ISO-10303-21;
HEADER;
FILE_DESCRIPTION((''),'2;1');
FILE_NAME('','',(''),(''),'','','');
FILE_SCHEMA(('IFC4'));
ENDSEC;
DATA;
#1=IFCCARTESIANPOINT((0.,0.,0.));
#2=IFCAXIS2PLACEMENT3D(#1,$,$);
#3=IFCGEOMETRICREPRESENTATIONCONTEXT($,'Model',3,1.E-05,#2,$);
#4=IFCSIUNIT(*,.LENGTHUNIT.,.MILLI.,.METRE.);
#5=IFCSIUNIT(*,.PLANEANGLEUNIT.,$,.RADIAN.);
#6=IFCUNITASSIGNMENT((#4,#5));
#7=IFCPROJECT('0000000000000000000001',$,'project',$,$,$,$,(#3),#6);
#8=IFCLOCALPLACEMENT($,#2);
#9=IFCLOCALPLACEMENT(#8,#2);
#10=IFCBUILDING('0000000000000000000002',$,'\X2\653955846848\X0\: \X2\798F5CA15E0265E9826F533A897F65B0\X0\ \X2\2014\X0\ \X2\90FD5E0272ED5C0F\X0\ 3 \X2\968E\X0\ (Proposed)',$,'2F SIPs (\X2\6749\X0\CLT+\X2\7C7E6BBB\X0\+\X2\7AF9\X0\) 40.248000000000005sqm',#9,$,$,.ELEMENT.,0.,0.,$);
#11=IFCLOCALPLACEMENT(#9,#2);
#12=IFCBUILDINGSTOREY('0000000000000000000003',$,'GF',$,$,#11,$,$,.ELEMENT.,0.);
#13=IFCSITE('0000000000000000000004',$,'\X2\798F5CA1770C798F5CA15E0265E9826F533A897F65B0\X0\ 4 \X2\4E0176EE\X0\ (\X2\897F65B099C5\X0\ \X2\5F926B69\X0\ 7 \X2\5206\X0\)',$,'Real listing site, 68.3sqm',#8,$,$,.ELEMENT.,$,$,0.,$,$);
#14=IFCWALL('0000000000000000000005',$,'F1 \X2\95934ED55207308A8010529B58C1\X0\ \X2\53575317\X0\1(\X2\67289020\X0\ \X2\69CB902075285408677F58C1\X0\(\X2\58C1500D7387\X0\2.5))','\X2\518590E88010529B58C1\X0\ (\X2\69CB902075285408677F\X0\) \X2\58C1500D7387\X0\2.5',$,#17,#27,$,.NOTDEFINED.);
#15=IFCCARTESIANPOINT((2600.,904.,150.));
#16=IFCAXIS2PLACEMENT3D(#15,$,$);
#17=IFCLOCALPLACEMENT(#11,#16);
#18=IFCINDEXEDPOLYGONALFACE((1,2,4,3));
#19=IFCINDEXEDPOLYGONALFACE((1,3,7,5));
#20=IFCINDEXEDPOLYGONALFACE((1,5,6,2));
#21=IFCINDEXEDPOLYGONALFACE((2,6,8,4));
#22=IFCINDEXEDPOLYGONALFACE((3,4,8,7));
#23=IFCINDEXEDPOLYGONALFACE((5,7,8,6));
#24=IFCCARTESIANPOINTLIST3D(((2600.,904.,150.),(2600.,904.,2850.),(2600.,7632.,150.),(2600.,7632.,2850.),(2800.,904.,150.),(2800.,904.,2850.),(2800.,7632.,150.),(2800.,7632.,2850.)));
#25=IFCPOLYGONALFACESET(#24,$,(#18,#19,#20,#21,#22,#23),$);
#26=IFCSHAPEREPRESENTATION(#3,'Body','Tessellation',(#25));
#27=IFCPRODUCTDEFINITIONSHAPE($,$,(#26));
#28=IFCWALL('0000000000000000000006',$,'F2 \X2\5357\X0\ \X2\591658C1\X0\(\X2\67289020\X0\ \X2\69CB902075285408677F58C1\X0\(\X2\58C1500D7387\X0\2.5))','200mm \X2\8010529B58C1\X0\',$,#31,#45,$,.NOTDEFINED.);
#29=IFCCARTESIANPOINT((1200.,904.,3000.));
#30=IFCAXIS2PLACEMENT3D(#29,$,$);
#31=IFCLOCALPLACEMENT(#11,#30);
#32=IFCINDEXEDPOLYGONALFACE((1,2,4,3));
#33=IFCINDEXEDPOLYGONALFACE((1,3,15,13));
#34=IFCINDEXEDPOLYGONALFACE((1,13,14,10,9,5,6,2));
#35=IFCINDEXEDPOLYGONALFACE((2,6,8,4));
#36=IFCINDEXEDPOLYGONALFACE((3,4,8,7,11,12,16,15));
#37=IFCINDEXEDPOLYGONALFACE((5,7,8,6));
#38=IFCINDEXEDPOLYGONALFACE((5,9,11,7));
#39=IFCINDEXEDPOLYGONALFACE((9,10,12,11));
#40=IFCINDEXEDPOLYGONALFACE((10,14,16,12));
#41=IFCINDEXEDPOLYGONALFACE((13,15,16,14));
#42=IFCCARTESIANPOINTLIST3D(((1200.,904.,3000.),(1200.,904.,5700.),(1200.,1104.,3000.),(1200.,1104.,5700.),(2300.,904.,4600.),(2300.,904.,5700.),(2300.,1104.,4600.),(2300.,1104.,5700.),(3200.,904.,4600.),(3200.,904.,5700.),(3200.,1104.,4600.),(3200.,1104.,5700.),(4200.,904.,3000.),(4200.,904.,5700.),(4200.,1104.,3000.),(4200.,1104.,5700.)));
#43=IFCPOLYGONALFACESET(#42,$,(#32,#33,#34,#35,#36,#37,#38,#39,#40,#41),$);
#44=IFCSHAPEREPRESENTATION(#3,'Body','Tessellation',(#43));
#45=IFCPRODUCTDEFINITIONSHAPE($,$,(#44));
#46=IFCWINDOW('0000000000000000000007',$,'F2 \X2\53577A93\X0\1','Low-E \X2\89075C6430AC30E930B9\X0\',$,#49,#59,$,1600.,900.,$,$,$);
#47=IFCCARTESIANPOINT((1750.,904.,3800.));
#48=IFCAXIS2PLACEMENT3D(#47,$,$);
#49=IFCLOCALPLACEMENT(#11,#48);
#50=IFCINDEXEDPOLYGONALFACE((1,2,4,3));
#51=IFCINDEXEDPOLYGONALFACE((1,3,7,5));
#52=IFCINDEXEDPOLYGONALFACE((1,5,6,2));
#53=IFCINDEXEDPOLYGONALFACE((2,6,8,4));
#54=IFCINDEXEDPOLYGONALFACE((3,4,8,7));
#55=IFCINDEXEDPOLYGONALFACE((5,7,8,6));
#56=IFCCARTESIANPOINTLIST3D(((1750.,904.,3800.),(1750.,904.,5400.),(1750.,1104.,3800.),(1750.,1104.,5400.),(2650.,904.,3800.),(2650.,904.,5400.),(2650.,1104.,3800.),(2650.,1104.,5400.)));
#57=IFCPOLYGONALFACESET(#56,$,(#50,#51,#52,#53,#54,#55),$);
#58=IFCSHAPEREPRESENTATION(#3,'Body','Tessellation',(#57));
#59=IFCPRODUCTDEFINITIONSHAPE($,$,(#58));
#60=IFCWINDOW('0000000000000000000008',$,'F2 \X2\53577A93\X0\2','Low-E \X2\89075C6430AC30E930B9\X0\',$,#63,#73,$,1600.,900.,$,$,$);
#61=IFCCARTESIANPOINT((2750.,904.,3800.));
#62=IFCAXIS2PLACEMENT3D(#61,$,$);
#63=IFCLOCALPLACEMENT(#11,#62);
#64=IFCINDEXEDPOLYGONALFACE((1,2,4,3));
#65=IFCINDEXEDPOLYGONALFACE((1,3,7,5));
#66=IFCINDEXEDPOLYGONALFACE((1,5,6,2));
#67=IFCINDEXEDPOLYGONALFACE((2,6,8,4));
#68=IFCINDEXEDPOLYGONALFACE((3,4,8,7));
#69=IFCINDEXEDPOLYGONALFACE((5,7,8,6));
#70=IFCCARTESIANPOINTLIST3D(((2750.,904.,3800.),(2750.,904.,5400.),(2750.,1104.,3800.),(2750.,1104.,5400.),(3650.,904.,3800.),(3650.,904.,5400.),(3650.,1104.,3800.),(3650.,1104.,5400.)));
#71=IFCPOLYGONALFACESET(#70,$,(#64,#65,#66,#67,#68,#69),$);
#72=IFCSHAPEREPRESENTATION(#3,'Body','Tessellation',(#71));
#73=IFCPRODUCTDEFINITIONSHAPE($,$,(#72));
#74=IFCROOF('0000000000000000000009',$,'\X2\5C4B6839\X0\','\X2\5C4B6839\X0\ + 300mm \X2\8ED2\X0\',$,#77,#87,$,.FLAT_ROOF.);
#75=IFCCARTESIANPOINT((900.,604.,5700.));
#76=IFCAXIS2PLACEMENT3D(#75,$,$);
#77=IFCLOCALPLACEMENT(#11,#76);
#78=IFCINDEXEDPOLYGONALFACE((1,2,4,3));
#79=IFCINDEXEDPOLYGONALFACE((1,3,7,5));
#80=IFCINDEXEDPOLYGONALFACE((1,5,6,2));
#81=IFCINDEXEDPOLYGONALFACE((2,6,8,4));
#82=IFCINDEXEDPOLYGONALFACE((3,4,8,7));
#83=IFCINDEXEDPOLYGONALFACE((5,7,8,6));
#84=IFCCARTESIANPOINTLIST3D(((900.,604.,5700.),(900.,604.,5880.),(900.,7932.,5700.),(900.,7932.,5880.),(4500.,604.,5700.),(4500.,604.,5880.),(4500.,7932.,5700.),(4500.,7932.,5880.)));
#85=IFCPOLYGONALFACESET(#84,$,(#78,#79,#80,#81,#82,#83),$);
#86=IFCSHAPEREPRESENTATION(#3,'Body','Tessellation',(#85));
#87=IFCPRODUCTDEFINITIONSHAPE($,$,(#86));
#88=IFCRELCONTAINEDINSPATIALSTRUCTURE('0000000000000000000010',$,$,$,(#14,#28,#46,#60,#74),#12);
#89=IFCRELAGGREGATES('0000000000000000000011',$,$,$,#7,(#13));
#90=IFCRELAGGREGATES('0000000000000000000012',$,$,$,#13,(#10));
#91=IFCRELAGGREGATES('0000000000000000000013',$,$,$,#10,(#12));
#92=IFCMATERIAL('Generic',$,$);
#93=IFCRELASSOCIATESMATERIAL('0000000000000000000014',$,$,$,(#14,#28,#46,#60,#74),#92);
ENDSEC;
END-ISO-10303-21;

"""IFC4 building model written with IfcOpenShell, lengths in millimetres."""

from ifc_helpers import new_model, si_unit, frame, frame_2d, origin, place, context, project, spatial, rectangle, extrude, material, element, fill, save


model = new_model("IFC4")

# Units and contexts
model_context = context("Model", 3, precision=1e-05, world=origin())
ifc_project = project(units=[si_unit("LENGTHUNIT", "METRE", prefix="MILLI"), si_unit("PLANEANGLEUNIT", "RADIAN")], contexts=[model_context])

# Site, building, storey
site_placement = place(None, origin())
site = spatial("IfcSite", under=ifc_project, at=site_placement, Name="福岡県福岡市早良区西新 4 丁目 (西新駅 徒歩 7 分)", ObjectType="Real listing site, 68.3sqm", CompositionType="ELEMENT", RefElevation=0.0)
building_placement = place(site_placement, origin())
building = spatial("IfcBuilding", under=site, at=building_placement, Name="改善案: 福岡市早良区西新 — 都市狭小 3 階 (Proposed)", ObjectType="2F SIPs (杉CLT+籾殻+竹) 40.248000000000005sqm", CompositionType="ELEMENT", ElevationOfRefHeight=0.0, ElevationOfTerrain=0.0)
storey_placement = place(building_placement, origin())
storey = spatial("IfcBuildingStorey", under=building, at=storey_placement, Name="GF", CompositionType="ELEMENT", Elevation=0.0)

# Shared definitions
ifc_material_1 = material(Name="Generic")

# Wall
wall_1_placement = place(storey_placement, frame((2600.0, 904.0, 150.0)))
element("IfcWall", 1, at=wall_1_placement, inside=storey, material=ifc_material_1, Name="F1 間仕切り耐力壁 南北1(木造 構造用合板壁(壁倍率2.5))", Description="内部耐力壁 (構造用合板) 壁倍率2.5", PredefinedType="NOTDEFINED", context=model_context, shape_type="SweptSolid", body=[
    extrude(rectangle(XDim=200.0, YDim=6728.0, at=frame_2d((100.0, 3364.0))), frame((2600.0, 904.0, 150.0)), (0.0, 0.0, 1.0), 2700.0),
])

# Wall, openings, windows
wall_2_placement = place(storey_placement, frame((1200.0, 904.0, 3000.0)))
wall_2 = element("IfcWall", 2, at=wall_2_placement, inside=storey, material=ifc_material_1, Name="F2 南 外壁(木造 構造用合板壁(壁倍率2.5))", Description="200mm 耐力壁", PredefinedType="NOTDEFINED", context=model_context, shape_type="SweptSolid", body=[
    extrude(rectangle(XDim=3000.0, YDim=200.0, at=frame_2d((1500.0, 100.0))), frame((1200.0, 904.0, 3000.0)), (0.0, 0.0, 1.0), 2700.0),
])
opening_1_placement = place(storey_placement, frame((1750.0, 904.0, 3800.0)))
opening_1 = element("IfcOpeningElement", 3, at=opening_1_placement, cuts=wall_2, PredefinedType="NOTDEFINED", context=model_context, shape_type="SweptSolid", body=[
    extrude(rectangle(XDim=900.0, YDim=200.0, at=frame_2d((450.0, 100.0))), frame((1750.0, 904.0, 3800.0)), (0.0, 0.0, 1.0), 1600.0),
])
opening_2_placement = place(storey_placement, frame((2750.0, 904.0, 3800.0)))
opening_2 = element("IfcOpeningElement", 4, at=opening_2_placement, cuts=wall_2, PredefinedType="NOTDEFINED", context=model_context, shape_type="SweptSolid", body=[
    extrude(rectangle(XDim=900.0, YDim=200.0, at=frame_2d((450.0, 100.0))), frame((2750.0, 904.0, 3800.0)), (0.0, 0.0, 1.0), 1600.0),
])
window_1_placement = place(storey_placement, frame((1750.0, 904.0, 3800.0)))
window_1 = element("IfcWindow", 5, at=window_1_placement, inside=storey, material=ifc_material_1, Name="F2 南窓1", Description="Low-E 複層ガラス", OverallHeight=1600.0, OverallWidth=900.0, context=model_context, shape_type="SweptSolid", body=[
    extrude(rectangle(XDim=900.0, YDim=200.0, at=frame_2d((450.0, 100.0))), frame((1750.0, 904.0, 3800.0)), (0.0, 0.0, 1.0), 1600.0),
])
fill(opening_1, window_1)
window_2_placement = place(storey_placement, frame((2750.0, 904.0, 3800.0)))
window_2 = element("IfcWindow", 6, at=window_2_placement, inside=storey, material=ifc_material_1, Name="F2 南窓2", Description="Low-E 複層ガラス", OverallHeight=1600.0, OverallWidth=900.0, context=model_context, shape_type="SweptSolid", body=[
    extrude(rectangle(XDim=900.0, YDim=200.0, at=frame_2d((450.0, 100.0))), frame((2750.0, 904.0, 3800.0)), (0.0, 0.0, 1.0), 1600.0),
])
fill(opening_2, window_2)

# Roof
roof_placement = place(storey_placement, frame((900.0, 604.0, 5700.0)))
element("IfcRoof", 7, at=roof_placement, inside=storey, material=ifc_material_1, Name="屋根", Description="屋根 + 300mm 軒", PredefinedType="FLAT_ROOF", context=model_context, shape_type="SweptSolid", body=[
    extrude(rectangle(XDim=3600.0, YDim=7328.0, at=frame_2d((1800.0, 3664.0))), frame((900.0, 604.0, 5700.0)), (0.0, 0.0, 1.0), 180.0),
])

save(model, "model.ifc")
